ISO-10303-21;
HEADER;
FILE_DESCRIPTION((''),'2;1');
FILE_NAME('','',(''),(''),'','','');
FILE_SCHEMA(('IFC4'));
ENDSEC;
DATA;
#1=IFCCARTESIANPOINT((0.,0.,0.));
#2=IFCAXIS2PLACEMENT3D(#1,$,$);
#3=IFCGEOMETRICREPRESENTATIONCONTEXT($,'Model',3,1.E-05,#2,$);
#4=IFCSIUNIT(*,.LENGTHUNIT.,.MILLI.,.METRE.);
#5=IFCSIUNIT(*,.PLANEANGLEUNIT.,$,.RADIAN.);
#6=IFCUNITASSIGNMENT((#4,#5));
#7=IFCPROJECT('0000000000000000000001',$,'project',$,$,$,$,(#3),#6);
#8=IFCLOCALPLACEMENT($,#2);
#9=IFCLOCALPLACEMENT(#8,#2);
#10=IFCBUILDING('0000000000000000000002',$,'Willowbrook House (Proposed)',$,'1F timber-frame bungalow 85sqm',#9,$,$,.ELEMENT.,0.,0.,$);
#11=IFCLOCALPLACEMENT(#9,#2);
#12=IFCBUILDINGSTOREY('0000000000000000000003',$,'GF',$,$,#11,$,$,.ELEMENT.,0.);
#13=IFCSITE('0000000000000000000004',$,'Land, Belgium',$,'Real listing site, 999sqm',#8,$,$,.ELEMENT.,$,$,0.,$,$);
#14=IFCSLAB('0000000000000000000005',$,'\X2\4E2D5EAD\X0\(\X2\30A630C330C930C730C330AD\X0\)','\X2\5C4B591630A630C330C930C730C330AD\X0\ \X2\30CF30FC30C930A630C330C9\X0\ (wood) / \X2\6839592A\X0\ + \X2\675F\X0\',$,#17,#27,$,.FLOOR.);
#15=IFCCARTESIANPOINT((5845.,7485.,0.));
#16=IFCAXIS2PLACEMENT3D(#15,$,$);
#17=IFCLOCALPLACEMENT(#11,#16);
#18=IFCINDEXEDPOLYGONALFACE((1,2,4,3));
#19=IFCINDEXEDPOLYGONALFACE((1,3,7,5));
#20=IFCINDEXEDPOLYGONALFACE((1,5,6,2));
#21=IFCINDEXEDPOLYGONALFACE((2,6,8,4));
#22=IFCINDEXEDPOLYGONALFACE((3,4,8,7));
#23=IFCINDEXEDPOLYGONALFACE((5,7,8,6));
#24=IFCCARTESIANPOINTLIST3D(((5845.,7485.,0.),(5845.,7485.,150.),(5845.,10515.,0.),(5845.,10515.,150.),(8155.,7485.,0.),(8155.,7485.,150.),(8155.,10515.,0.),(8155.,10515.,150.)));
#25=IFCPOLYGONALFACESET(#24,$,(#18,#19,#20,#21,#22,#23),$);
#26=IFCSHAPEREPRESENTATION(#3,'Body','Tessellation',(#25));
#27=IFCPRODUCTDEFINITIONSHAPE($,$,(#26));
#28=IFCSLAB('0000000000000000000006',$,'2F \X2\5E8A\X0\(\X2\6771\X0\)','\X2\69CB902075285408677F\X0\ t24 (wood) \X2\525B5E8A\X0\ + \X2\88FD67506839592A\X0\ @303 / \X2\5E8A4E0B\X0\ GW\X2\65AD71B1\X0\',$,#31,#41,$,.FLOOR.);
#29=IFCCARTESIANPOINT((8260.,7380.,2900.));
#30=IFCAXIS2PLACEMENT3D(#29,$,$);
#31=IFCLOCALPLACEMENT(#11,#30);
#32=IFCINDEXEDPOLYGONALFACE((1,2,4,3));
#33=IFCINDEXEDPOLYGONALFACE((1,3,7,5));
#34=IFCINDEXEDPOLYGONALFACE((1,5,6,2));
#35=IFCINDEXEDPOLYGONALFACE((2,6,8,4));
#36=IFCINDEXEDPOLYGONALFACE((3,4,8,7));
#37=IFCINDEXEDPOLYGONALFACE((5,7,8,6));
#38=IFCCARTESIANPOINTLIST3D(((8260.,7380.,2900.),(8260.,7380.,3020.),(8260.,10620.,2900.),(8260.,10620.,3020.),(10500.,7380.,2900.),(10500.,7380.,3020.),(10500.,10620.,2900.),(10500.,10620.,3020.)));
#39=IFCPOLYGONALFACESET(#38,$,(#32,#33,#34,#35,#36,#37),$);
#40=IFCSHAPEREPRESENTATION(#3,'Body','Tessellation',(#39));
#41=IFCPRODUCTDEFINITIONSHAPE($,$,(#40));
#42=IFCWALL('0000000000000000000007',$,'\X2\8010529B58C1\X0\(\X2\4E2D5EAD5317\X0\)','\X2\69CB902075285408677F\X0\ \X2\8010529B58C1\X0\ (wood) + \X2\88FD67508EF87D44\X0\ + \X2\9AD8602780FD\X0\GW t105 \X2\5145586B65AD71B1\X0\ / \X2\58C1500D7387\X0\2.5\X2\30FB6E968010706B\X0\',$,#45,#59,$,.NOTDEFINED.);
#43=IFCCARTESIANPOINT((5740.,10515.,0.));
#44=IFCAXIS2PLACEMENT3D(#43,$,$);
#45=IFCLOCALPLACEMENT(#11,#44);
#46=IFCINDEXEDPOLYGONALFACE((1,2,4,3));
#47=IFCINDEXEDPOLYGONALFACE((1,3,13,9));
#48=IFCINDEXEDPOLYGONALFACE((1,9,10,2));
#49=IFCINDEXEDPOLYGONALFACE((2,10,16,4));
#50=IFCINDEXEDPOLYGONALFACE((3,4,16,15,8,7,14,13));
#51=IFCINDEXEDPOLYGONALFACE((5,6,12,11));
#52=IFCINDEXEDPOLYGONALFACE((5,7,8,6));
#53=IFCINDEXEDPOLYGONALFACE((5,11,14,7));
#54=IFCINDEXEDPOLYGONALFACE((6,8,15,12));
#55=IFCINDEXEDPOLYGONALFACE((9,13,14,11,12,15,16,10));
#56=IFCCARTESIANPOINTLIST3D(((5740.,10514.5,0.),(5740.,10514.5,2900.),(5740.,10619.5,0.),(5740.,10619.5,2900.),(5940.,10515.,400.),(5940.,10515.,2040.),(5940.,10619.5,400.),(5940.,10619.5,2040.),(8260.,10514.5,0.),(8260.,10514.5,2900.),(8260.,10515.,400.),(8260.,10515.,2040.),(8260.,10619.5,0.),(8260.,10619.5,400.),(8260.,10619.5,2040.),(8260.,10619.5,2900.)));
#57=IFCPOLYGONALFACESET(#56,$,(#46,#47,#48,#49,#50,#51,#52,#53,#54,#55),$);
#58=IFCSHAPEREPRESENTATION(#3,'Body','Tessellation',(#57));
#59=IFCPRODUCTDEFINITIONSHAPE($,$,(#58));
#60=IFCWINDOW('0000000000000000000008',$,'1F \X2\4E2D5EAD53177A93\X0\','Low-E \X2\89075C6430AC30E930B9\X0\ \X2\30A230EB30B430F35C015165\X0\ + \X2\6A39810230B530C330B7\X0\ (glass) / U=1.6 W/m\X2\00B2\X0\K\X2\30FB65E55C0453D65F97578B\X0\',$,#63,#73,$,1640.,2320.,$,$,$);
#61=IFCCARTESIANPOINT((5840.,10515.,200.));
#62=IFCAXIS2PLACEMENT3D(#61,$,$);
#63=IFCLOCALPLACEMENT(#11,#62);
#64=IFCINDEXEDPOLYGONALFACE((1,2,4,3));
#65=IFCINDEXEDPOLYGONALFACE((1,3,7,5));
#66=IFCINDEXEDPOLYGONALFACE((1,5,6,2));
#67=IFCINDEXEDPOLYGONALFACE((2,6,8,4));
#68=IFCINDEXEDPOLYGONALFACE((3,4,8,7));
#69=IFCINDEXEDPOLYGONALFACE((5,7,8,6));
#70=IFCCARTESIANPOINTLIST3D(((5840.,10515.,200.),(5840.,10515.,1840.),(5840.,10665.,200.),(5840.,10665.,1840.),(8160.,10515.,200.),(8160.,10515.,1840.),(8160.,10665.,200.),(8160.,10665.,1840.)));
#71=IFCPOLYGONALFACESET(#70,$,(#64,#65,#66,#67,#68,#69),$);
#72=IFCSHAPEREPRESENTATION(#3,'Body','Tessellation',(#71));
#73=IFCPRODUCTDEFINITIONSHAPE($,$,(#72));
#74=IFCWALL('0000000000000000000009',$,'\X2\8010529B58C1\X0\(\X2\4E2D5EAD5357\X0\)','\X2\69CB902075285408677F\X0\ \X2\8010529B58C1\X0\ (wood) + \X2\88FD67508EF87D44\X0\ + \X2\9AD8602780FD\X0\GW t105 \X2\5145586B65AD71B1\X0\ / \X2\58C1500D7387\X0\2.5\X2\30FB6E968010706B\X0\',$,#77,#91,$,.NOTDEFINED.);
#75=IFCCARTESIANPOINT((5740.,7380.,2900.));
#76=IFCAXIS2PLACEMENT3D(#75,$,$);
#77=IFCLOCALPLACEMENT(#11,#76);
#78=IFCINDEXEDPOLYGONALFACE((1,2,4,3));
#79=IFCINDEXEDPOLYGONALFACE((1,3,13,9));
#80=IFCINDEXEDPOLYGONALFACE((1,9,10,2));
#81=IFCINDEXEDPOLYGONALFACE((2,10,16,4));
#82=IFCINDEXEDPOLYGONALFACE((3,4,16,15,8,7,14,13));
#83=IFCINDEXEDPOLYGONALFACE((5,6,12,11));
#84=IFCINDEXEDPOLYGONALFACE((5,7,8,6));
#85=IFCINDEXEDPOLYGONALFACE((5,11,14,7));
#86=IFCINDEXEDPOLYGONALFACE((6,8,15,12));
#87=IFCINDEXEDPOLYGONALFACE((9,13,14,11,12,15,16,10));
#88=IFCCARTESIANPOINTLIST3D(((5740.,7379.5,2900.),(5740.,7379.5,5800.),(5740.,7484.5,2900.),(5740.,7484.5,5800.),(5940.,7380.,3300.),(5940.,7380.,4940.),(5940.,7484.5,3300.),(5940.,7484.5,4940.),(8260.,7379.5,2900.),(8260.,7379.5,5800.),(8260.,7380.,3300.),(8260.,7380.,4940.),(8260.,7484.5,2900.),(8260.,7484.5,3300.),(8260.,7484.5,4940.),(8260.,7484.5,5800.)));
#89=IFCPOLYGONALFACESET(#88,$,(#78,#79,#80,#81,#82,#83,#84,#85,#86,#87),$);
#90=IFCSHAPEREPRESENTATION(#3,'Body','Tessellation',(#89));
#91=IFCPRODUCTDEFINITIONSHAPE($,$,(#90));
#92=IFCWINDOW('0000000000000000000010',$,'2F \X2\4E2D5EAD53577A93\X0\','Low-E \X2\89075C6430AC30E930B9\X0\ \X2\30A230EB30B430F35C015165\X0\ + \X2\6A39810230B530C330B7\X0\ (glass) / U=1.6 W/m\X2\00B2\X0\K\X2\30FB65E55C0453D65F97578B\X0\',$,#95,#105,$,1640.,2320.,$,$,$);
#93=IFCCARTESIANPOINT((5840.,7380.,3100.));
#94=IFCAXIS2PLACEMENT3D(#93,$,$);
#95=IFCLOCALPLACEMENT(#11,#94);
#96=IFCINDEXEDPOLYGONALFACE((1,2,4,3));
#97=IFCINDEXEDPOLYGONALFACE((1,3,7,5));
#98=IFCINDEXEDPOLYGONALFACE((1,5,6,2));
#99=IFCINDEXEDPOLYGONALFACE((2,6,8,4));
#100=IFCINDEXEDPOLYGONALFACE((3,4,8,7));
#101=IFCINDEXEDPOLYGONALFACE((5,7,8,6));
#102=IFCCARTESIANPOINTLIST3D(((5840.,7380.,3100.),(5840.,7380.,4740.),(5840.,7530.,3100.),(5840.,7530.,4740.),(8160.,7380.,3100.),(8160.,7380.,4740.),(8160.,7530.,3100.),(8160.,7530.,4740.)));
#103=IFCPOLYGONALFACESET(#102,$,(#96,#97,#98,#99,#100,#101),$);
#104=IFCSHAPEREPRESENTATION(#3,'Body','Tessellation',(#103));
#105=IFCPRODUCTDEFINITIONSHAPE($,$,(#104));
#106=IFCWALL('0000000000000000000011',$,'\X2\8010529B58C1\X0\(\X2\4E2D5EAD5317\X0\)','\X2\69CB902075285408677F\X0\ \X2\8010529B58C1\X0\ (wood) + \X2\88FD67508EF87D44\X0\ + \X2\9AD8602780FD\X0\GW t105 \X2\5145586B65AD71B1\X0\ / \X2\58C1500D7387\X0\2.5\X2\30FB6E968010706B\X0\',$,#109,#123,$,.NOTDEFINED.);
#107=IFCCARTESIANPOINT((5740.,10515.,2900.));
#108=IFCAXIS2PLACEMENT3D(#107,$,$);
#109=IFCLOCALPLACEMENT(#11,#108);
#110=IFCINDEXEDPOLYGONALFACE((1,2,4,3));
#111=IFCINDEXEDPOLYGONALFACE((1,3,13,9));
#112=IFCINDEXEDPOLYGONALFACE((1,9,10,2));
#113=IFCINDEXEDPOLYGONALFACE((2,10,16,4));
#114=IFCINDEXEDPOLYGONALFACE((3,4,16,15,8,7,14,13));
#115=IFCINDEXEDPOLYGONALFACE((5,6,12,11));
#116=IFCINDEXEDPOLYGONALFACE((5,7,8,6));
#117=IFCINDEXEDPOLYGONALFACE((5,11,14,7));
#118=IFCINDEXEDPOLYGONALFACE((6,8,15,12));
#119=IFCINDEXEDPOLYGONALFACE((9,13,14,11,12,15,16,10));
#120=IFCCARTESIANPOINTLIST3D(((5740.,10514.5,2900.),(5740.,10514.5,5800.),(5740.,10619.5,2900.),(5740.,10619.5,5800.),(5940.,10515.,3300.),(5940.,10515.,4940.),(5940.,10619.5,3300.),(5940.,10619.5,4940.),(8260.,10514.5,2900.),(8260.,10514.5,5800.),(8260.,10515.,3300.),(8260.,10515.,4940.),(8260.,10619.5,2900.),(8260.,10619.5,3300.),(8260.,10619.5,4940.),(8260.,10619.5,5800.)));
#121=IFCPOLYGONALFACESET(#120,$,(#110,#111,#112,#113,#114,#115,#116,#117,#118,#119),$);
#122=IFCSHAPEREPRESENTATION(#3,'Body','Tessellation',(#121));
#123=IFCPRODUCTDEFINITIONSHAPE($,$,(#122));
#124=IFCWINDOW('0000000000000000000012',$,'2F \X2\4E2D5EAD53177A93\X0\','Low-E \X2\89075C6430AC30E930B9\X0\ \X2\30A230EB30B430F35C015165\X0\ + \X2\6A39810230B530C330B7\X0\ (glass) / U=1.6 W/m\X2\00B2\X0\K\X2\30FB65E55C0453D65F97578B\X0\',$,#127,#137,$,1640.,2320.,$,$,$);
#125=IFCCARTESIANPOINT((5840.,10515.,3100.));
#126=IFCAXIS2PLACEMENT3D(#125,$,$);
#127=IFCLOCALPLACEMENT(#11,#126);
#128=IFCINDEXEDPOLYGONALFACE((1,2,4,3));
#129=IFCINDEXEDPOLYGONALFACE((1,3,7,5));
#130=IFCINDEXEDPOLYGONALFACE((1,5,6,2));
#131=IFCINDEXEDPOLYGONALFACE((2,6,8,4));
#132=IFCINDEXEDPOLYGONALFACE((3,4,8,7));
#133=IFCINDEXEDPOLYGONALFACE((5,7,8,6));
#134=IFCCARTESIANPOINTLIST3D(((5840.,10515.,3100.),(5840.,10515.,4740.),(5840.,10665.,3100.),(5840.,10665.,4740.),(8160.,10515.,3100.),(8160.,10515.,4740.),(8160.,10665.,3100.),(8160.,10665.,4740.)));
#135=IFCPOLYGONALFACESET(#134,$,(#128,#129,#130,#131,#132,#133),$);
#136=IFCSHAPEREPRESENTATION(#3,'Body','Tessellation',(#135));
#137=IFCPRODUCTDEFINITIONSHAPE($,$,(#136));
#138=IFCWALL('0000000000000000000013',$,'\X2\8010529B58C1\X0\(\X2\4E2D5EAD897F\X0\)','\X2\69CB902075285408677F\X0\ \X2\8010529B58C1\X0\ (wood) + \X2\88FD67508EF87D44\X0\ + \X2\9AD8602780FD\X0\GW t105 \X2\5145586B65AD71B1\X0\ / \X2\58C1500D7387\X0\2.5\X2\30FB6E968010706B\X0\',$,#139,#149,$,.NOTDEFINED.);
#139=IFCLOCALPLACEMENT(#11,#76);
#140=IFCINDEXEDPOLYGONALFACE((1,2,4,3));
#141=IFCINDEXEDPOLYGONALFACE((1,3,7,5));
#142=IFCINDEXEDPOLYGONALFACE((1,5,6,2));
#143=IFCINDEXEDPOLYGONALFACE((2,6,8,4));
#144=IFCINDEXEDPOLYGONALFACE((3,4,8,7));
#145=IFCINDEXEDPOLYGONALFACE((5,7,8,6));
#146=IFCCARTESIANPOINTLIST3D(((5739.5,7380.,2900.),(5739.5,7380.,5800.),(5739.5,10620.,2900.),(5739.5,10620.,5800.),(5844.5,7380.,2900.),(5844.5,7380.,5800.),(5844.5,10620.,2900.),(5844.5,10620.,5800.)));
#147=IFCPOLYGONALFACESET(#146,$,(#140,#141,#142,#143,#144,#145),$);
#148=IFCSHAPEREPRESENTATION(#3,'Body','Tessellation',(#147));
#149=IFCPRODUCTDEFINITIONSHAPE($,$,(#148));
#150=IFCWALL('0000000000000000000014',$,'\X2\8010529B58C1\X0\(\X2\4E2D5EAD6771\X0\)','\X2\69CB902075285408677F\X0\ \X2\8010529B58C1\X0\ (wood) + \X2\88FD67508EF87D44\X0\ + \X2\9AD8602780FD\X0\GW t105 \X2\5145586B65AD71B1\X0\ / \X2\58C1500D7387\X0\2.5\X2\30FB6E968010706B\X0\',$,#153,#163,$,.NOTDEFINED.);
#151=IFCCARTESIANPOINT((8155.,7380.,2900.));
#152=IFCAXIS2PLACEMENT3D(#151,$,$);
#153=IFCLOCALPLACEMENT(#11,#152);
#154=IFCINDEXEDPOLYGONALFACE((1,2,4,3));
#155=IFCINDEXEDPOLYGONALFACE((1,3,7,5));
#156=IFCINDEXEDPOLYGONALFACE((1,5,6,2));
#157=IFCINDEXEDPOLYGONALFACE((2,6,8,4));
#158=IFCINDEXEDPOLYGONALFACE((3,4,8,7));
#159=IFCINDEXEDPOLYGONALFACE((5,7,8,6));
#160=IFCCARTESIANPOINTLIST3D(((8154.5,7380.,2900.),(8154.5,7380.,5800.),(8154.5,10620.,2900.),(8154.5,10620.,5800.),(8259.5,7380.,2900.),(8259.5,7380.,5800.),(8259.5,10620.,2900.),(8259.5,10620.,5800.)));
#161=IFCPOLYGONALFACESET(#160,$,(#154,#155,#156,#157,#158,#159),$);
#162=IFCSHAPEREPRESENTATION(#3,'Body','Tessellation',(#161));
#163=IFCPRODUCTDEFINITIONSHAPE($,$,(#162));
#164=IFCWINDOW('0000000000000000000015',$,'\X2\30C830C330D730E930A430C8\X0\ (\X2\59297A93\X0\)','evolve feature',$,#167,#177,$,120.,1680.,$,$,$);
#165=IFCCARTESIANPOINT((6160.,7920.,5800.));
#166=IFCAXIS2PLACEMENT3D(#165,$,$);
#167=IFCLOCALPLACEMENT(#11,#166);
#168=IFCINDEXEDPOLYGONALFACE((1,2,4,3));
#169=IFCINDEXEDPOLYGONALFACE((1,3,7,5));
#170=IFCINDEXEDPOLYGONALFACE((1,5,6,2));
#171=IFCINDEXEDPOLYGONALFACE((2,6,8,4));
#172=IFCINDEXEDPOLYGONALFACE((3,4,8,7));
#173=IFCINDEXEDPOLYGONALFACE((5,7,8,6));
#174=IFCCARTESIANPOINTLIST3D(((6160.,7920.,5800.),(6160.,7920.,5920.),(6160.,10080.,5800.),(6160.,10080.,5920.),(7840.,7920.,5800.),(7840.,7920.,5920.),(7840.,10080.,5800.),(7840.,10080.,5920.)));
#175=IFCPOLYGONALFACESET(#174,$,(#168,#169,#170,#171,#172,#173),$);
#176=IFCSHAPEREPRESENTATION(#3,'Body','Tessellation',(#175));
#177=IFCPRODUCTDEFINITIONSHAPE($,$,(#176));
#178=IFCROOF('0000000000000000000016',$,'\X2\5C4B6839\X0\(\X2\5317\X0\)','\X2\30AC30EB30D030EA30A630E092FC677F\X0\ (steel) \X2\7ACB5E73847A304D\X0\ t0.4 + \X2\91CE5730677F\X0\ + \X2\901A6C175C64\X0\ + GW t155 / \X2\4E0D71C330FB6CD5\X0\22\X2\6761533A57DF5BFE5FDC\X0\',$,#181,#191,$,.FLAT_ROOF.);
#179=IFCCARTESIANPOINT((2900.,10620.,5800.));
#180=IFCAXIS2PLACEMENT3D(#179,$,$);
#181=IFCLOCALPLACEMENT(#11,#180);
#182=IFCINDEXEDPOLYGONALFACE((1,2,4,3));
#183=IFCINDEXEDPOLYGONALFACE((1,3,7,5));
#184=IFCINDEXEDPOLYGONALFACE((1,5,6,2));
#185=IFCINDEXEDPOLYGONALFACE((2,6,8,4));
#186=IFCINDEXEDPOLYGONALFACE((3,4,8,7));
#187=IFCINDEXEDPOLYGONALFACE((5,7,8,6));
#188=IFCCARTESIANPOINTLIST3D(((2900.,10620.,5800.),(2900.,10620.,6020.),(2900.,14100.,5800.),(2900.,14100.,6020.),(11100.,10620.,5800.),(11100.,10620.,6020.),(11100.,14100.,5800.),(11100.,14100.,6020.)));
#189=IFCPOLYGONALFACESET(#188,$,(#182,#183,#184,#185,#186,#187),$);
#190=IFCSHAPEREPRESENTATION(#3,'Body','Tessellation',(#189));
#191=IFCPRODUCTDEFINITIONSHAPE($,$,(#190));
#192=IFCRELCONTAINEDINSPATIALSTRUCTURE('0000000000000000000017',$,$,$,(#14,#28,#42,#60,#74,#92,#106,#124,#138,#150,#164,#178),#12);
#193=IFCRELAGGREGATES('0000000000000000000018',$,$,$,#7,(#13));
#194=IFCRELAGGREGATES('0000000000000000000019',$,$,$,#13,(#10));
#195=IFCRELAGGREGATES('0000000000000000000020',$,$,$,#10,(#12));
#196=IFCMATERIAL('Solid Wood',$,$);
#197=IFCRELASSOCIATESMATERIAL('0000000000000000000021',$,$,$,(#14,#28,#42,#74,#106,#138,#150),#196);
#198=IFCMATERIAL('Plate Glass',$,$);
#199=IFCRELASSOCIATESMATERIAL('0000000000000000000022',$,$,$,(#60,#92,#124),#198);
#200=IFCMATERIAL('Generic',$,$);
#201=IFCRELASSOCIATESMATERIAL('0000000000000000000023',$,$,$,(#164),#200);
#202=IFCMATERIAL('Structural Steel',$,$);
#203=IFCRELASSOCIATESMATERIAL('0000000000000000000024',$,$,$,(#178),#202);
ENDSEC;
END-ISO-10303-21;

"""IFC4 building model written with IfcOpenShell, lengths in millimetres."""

from ifc_helpers import new_model, si_unit, frame, frame_2d, origin, place, context, project, spatial, rectangle, extrude, material, element, fill, save


model = new_model("IFC4")

# Units and contexts
model_context = context("Model", 3, precision=1e-05, world=origin())
ifc_project = project(units=[si_unit("LENGTHUNIT", "METRE", prefix="MILLI"), si_unit("PLANEANGLEUNIT", "RADIAN")], contexts=[model_context])

# Site, building, storey
site_placement = place(None, origin())
site = spatial("IfcSite", under=ifc_project, at=site_placement, Name="Land, Belgium", ObjectType="Real listing site, 999sqm", CompositionType="ELEMENT", RefElevation=0.0)
building_placement = place(site_placement, origin())
building = spatial("IfcBuilding", under=site, at=building_placement, Name="Willowbrook House (Proposed)", ObjectType="1F timber-frame bungalow 85sqm", CompositionType="ELEMENT", ElevationOfRefHeight=0.0, ElevationOfTerrain=0.0)
storey_placement = place(building_placement, origin())
storey = spatial("IfcBuildingStorey", under=building, at=storey_placement, Name="GF", CompositionType="ELEMENT", Elevation=0.0)

# Slabs
ifc_material_1 = material(Name="Solid Wood")
slab_1_placement = place(storey_placement, frame((5845.0, 7485.0, 0.0)))
element("IfcSlab", 1, at=slab_1_placement, inside=storey, material=ifc_material_1, Name="中庭(ウッドデッキ)", Description="屋外ウッドデッキ ハードウッド (wood) / 根太 + 束", PredefinedType="FLOOR", context=model_context, shape_type="SweptSolid", body=[
    extrude(rectangle(XDim=2310.0, YDim=3030.0, at=frame_2d((1155.0, 1515.0))), frame((5845.0, 7485.0, 0.0)), (0.0, 0.0, 1.0), 150.0),
])
slab_2_placement = place(storey_placement, frame((8260.0, 7380.0, 2900.0)))
element("IfcSlab", 2, at=slab_2_placement, inside=storey, material=ifc_material_1, Name="2F 床(東)", Description="構造用合板 t24 (wood) 剛床 + 製材根太 @303 / 床下 GW断熱", PredefinedType="FLOOR", context=model_context, shape_type="SweptSolid", body=[
    extrude(rectangle(XDim=2240.0, YDim=3240.0, at=frame_2d((1120.0, 1620.0))), frame((8260.0, 7380.0, 2900.0)), (0.0, 0.0, 1.0), 120.0),
])

# Walls, openings, windows
wall_1_placement = place(storey_placement, frame((5740.0, 10515.0, 0.0)))
wall_1 = element("IfcWall", 3, at=wall_1_placement, inside=storey, material=ifc_material_1, Name="耐力壁(中庭北)", Description="構造用合板 耐力壁 (wood) + 製材軸組 + 高性能GW t105 充填断熱 / 壁倍率2.5・準耐火", PredefinedType="NOTDEFINED", context=model_context, shape_type="SweptSolid", body=[
    extrude(rectangle(XDim=2520.0, YDim=105.0, at=frame_2d((1260.0, 52.0))), frame((5740.0, 10515.0, 0.0)), (0.0, 0.0, 1.0), 2900.0),
])
opening_1_placement = place(storey_placement, frame((5840.0, 10515.0, 200.0)))
opening_1 = element("IfcOpeningElement", 4, at=opening_1_placement, cuts=wall_1, PredefinedType="NOTDEFINED", context=model_context, shape_type="SweptSolid", body=[
    extrude(rectangle(XDim=2320.0, YDim=150.0, at=frame_2d((1160.0, 75.0))), frame((5840.0, 10515.0, 200.0)), (0.0, 0.0, 1.0), 1640.0),
])
ifc_material_2 = material(Name="Plate Glass")
window_1_placement = place(storey_placement, frame((5840.0, 10515.0, 200.0)))
window_1 = element("IfcWindow", 5, at=window_1_placement, inside=storey, material=ifc_material_2, Name="1F 中庭北窓", Description="Low-E 複層ガラス アルゴン封入 + 樹脂サッシ (glass) / U=1.6 W/m²K・日射取得型", OverallHeight=1640.0, OverallWidth=2320.0, context=model_context, shape_type="SweptSolid", body=[
    extrude(rectangle(XDim=2320.0, YDim=150.0, at=frame_2d((1160.0, 75.0))), frame((5840.0, 10515.0, 200.0)), (0.0, 0.0, 1.0), 1640.0),
])
fill(opening_1, window_1)
wall_2_placement = place(storey_placement, frame((5740.0, 7380.0, 2900.0)))
wall_2 = element("IfcWall", 6, at=wall_2_placement, inside=storey, material=ifc_material_1, Name="耐力壁(中庭南)", Description="構造用合板 耐力壁 (wood) + 製材軸組 + 高性能GW t105 充填断熱 / 壁倍率2.5・準耐火", PredefinedType="NOTDEFINED", context=model_context, shape_type="SweptSolid", body=[
    extrude(rectangle(XDim=2520.0, YDim=105.0, at=frame_2d((1260.0, 52.0))), frame((5740.0, 7380.0, 2900.0)), (0.0, 0.0, 1.0), 2900.0),
])
opening_2_placement = place(storey_placement, frame((5840.0, 7380.0, 3100.0)))
opening_2 = element("IfcOpeningElement", 7, at=opening_2_placement, cuts=wall_2, PredefinedType="NOTDEFINED", context=model_context, shape_type="SweptSolid", body=[
    extrude(rectangle(XDim=2320.0, YDim=150.0, at=frame_2d((1160.0, 75.0))), frame((5840.0, 7380.0, 3100.0)), (0.0, 0.0, 1.0), 1640.0),
])
window_2_placement = place(storey_placement, frame((5840.0, 7380.0, 3100.0)))
window_2 = element("IfcWindow", 8, at=window_2_placement, inside=storey, material=ifc_material_2, Name="2F 中庭南窓", Description="Low-E 複層ガラス アルゴン封入 + 樹脂サッシ (glass) / U=1.6 W/m²K・日射取得型", OverallHeight=1640.0, OverallWidth=2320.0, context=model_context, shape_type="SweptSolid", body=[
    extrude(rectangle(XDim=2320.0, YDim=150.0, at=frame_2d((1160.0, 75.0))), frame((5840.0, 7380.0, 3100.0)), (0.0, 0.0, 1.0), 1640.0),
])
fill(opening_2, window_2)
wall_3_placement = place(storey_placement, frame((5740.0, 10515.0, 2900.0)))
wall_3 = element("IfcWall", 9, at=wall_3_placement, inside=storey, material=ifc_material_1, Name="耐力壁(中庭北)", Description="構造用合板 耐力壁 (wood) + 製材軸組 + 高性能GW t105 充填断熱 / 壁倍率2.5・準耐火", PredefinedType="NOTDEFINED", context=model_context, shape_type="SweptSolid", body=[
    extrude(rectangle(XDim=2520.0, YDim=105.0, at=frame_2d((1260.0, 52.0))), frame((5740.0, 10515.0, 2900.0)), (0.0, 0.0, 1.0), 2900.0),
])
opening_3_placement = place(storey_placement, frame((5840.0, 10515.0, 3100.0)))
opening_3 = element("IfcOpeningElement", 10, at=opening_3_placement, cuts=wall_3, PredefinedType="NOTDEFINED", context=model_context, shape_type="SweptSolid", body=[
    extrude(rectangle(XDim=2320.0, YDim=150.0, at=frame_2d((1160.0, 75.0))), frame((5840.0, 10515.0, 3100.0)), (0.0, 0.0, 1.0), 1640.0),
])
window_3_placement = place(storey_placement, frame((5840.0, 10515.0, 3100.0)))
window_3 = element("IfcWindow", 11, at=window_3_placement, inside=storey, material=ifc_material_2, Name="2F 中庭北窓", Description="Low-E 複層ガラス アルゴン封入 + 樹脂サッシ (glass) / U=1.6 W/m²K・日射取得型", OverallHeight=1640.0, OverallWidth=2320.0, context=model_context, shape_type="SweptSolid", body=[
    extrude(rectangle(XDim=2320.0, YDim=150.0, at=frame_2d((1160.0, 75.0))), frame((5840.0, 10515.0, 3100.0)), (0.0, 0.0, 1.0), 1640.0),
])
fill(opening_3, window_3)

# Walls
wall_4_placement = place(storey_placement, frame((5740.0, 7380.0, 2900.0)))
element("IfcWall", 12, at=wall_4_placement, inside=storey, material=ifc_material_1, Name="耐力壁(中庭西)", Description="構造用合板 耐力壁 (wood) + 製材軸組 + 高性能GW t105 充填断熱 / 壁倍率2.5・準耐火", PredefinedType="NOTDEFINED", context=model_context, shape_type="SweptSolid", body=[
    extrude(rectangle(XDim=105.0, YDim=3240.0, at=frame_2d((52.0, 1620.0))), frame((5740.0, 7380.0, 2900.0)), (0.0, 0.0, 1.0), 2900.0),
])
wall_5_placement = place(storey_placement, frame((8155.0, 7380.0, 2900.0)))
element("IfcWall", 13, at=wall_5_placement, inside=storey, material=ifc_material_1, Name="耐力壁(中庭東)", Description="構造用合板 耐力壁 (wood) + 製材軸組 + 高性能GW t105 充填断熱 / 壁倍率2.5・準耐火", PredefinedType="NOTDEFINED", context=model_context, shape_type="SweptSolid", body=[
    extrude(rectangle(XDim=105.0, YDim=3240.0, at=frame_2d((52.0, 1620.0))), frame((8155.0, 7380.0, 2900.0)), (0.0, 0.0, 1.0), 2900.0),
])

# Window
ifc_material_3 = material(Name="Generic")
window_4_placement = place(storey_placement, frame((6160.0, 7920.0, 5800.0)))
element("IfcWindow", 14, at=window_4_placement, inside=storey, material=ifc_material_3, Name="トップライト (天窓)", Description="evolve feature", OverallHeight=120.0, OverallWidth=1680.0, context=model_context, shape_type="SweptSolid", body=[
    extrude(rectangle(XDim=1680.0, YDim=2160.0, at=frame_2d((840.0, 1080.0))), frame((6160.0, 7920.0, 5800.0)), (0.0, 0.0, 1.0), 120.0),
])

# Roof
ifc_material_4 = material(Name="Structural Steel")
roof_1_placement = place(storey_placement, frame((2900.0, 10620.0, 5800.0)))
element("IfcRoof", 15, at=roof_1_placement, inside=storey, material=ifc_material_4, Name="屋根(北)", Description="ガルバリウム鋼板 (steel) 立平葺き t0.4 + 野地板 + 通気層 + GW t155 / 不燃・法22条区域対応", PredefinedType="FLAT_ROOF", context=model_context, shape_type="SweptSolid", body=[
    extrude(rectangle(XDim=8200.0, YDim=3480.0, at=frame_2d((4100.0, 1740.0))), frame((2900.0, 10620.0, 5800.0)), (0.0, 0.0, 1.0), 220.0),
])

save(model, "model.ifc")
